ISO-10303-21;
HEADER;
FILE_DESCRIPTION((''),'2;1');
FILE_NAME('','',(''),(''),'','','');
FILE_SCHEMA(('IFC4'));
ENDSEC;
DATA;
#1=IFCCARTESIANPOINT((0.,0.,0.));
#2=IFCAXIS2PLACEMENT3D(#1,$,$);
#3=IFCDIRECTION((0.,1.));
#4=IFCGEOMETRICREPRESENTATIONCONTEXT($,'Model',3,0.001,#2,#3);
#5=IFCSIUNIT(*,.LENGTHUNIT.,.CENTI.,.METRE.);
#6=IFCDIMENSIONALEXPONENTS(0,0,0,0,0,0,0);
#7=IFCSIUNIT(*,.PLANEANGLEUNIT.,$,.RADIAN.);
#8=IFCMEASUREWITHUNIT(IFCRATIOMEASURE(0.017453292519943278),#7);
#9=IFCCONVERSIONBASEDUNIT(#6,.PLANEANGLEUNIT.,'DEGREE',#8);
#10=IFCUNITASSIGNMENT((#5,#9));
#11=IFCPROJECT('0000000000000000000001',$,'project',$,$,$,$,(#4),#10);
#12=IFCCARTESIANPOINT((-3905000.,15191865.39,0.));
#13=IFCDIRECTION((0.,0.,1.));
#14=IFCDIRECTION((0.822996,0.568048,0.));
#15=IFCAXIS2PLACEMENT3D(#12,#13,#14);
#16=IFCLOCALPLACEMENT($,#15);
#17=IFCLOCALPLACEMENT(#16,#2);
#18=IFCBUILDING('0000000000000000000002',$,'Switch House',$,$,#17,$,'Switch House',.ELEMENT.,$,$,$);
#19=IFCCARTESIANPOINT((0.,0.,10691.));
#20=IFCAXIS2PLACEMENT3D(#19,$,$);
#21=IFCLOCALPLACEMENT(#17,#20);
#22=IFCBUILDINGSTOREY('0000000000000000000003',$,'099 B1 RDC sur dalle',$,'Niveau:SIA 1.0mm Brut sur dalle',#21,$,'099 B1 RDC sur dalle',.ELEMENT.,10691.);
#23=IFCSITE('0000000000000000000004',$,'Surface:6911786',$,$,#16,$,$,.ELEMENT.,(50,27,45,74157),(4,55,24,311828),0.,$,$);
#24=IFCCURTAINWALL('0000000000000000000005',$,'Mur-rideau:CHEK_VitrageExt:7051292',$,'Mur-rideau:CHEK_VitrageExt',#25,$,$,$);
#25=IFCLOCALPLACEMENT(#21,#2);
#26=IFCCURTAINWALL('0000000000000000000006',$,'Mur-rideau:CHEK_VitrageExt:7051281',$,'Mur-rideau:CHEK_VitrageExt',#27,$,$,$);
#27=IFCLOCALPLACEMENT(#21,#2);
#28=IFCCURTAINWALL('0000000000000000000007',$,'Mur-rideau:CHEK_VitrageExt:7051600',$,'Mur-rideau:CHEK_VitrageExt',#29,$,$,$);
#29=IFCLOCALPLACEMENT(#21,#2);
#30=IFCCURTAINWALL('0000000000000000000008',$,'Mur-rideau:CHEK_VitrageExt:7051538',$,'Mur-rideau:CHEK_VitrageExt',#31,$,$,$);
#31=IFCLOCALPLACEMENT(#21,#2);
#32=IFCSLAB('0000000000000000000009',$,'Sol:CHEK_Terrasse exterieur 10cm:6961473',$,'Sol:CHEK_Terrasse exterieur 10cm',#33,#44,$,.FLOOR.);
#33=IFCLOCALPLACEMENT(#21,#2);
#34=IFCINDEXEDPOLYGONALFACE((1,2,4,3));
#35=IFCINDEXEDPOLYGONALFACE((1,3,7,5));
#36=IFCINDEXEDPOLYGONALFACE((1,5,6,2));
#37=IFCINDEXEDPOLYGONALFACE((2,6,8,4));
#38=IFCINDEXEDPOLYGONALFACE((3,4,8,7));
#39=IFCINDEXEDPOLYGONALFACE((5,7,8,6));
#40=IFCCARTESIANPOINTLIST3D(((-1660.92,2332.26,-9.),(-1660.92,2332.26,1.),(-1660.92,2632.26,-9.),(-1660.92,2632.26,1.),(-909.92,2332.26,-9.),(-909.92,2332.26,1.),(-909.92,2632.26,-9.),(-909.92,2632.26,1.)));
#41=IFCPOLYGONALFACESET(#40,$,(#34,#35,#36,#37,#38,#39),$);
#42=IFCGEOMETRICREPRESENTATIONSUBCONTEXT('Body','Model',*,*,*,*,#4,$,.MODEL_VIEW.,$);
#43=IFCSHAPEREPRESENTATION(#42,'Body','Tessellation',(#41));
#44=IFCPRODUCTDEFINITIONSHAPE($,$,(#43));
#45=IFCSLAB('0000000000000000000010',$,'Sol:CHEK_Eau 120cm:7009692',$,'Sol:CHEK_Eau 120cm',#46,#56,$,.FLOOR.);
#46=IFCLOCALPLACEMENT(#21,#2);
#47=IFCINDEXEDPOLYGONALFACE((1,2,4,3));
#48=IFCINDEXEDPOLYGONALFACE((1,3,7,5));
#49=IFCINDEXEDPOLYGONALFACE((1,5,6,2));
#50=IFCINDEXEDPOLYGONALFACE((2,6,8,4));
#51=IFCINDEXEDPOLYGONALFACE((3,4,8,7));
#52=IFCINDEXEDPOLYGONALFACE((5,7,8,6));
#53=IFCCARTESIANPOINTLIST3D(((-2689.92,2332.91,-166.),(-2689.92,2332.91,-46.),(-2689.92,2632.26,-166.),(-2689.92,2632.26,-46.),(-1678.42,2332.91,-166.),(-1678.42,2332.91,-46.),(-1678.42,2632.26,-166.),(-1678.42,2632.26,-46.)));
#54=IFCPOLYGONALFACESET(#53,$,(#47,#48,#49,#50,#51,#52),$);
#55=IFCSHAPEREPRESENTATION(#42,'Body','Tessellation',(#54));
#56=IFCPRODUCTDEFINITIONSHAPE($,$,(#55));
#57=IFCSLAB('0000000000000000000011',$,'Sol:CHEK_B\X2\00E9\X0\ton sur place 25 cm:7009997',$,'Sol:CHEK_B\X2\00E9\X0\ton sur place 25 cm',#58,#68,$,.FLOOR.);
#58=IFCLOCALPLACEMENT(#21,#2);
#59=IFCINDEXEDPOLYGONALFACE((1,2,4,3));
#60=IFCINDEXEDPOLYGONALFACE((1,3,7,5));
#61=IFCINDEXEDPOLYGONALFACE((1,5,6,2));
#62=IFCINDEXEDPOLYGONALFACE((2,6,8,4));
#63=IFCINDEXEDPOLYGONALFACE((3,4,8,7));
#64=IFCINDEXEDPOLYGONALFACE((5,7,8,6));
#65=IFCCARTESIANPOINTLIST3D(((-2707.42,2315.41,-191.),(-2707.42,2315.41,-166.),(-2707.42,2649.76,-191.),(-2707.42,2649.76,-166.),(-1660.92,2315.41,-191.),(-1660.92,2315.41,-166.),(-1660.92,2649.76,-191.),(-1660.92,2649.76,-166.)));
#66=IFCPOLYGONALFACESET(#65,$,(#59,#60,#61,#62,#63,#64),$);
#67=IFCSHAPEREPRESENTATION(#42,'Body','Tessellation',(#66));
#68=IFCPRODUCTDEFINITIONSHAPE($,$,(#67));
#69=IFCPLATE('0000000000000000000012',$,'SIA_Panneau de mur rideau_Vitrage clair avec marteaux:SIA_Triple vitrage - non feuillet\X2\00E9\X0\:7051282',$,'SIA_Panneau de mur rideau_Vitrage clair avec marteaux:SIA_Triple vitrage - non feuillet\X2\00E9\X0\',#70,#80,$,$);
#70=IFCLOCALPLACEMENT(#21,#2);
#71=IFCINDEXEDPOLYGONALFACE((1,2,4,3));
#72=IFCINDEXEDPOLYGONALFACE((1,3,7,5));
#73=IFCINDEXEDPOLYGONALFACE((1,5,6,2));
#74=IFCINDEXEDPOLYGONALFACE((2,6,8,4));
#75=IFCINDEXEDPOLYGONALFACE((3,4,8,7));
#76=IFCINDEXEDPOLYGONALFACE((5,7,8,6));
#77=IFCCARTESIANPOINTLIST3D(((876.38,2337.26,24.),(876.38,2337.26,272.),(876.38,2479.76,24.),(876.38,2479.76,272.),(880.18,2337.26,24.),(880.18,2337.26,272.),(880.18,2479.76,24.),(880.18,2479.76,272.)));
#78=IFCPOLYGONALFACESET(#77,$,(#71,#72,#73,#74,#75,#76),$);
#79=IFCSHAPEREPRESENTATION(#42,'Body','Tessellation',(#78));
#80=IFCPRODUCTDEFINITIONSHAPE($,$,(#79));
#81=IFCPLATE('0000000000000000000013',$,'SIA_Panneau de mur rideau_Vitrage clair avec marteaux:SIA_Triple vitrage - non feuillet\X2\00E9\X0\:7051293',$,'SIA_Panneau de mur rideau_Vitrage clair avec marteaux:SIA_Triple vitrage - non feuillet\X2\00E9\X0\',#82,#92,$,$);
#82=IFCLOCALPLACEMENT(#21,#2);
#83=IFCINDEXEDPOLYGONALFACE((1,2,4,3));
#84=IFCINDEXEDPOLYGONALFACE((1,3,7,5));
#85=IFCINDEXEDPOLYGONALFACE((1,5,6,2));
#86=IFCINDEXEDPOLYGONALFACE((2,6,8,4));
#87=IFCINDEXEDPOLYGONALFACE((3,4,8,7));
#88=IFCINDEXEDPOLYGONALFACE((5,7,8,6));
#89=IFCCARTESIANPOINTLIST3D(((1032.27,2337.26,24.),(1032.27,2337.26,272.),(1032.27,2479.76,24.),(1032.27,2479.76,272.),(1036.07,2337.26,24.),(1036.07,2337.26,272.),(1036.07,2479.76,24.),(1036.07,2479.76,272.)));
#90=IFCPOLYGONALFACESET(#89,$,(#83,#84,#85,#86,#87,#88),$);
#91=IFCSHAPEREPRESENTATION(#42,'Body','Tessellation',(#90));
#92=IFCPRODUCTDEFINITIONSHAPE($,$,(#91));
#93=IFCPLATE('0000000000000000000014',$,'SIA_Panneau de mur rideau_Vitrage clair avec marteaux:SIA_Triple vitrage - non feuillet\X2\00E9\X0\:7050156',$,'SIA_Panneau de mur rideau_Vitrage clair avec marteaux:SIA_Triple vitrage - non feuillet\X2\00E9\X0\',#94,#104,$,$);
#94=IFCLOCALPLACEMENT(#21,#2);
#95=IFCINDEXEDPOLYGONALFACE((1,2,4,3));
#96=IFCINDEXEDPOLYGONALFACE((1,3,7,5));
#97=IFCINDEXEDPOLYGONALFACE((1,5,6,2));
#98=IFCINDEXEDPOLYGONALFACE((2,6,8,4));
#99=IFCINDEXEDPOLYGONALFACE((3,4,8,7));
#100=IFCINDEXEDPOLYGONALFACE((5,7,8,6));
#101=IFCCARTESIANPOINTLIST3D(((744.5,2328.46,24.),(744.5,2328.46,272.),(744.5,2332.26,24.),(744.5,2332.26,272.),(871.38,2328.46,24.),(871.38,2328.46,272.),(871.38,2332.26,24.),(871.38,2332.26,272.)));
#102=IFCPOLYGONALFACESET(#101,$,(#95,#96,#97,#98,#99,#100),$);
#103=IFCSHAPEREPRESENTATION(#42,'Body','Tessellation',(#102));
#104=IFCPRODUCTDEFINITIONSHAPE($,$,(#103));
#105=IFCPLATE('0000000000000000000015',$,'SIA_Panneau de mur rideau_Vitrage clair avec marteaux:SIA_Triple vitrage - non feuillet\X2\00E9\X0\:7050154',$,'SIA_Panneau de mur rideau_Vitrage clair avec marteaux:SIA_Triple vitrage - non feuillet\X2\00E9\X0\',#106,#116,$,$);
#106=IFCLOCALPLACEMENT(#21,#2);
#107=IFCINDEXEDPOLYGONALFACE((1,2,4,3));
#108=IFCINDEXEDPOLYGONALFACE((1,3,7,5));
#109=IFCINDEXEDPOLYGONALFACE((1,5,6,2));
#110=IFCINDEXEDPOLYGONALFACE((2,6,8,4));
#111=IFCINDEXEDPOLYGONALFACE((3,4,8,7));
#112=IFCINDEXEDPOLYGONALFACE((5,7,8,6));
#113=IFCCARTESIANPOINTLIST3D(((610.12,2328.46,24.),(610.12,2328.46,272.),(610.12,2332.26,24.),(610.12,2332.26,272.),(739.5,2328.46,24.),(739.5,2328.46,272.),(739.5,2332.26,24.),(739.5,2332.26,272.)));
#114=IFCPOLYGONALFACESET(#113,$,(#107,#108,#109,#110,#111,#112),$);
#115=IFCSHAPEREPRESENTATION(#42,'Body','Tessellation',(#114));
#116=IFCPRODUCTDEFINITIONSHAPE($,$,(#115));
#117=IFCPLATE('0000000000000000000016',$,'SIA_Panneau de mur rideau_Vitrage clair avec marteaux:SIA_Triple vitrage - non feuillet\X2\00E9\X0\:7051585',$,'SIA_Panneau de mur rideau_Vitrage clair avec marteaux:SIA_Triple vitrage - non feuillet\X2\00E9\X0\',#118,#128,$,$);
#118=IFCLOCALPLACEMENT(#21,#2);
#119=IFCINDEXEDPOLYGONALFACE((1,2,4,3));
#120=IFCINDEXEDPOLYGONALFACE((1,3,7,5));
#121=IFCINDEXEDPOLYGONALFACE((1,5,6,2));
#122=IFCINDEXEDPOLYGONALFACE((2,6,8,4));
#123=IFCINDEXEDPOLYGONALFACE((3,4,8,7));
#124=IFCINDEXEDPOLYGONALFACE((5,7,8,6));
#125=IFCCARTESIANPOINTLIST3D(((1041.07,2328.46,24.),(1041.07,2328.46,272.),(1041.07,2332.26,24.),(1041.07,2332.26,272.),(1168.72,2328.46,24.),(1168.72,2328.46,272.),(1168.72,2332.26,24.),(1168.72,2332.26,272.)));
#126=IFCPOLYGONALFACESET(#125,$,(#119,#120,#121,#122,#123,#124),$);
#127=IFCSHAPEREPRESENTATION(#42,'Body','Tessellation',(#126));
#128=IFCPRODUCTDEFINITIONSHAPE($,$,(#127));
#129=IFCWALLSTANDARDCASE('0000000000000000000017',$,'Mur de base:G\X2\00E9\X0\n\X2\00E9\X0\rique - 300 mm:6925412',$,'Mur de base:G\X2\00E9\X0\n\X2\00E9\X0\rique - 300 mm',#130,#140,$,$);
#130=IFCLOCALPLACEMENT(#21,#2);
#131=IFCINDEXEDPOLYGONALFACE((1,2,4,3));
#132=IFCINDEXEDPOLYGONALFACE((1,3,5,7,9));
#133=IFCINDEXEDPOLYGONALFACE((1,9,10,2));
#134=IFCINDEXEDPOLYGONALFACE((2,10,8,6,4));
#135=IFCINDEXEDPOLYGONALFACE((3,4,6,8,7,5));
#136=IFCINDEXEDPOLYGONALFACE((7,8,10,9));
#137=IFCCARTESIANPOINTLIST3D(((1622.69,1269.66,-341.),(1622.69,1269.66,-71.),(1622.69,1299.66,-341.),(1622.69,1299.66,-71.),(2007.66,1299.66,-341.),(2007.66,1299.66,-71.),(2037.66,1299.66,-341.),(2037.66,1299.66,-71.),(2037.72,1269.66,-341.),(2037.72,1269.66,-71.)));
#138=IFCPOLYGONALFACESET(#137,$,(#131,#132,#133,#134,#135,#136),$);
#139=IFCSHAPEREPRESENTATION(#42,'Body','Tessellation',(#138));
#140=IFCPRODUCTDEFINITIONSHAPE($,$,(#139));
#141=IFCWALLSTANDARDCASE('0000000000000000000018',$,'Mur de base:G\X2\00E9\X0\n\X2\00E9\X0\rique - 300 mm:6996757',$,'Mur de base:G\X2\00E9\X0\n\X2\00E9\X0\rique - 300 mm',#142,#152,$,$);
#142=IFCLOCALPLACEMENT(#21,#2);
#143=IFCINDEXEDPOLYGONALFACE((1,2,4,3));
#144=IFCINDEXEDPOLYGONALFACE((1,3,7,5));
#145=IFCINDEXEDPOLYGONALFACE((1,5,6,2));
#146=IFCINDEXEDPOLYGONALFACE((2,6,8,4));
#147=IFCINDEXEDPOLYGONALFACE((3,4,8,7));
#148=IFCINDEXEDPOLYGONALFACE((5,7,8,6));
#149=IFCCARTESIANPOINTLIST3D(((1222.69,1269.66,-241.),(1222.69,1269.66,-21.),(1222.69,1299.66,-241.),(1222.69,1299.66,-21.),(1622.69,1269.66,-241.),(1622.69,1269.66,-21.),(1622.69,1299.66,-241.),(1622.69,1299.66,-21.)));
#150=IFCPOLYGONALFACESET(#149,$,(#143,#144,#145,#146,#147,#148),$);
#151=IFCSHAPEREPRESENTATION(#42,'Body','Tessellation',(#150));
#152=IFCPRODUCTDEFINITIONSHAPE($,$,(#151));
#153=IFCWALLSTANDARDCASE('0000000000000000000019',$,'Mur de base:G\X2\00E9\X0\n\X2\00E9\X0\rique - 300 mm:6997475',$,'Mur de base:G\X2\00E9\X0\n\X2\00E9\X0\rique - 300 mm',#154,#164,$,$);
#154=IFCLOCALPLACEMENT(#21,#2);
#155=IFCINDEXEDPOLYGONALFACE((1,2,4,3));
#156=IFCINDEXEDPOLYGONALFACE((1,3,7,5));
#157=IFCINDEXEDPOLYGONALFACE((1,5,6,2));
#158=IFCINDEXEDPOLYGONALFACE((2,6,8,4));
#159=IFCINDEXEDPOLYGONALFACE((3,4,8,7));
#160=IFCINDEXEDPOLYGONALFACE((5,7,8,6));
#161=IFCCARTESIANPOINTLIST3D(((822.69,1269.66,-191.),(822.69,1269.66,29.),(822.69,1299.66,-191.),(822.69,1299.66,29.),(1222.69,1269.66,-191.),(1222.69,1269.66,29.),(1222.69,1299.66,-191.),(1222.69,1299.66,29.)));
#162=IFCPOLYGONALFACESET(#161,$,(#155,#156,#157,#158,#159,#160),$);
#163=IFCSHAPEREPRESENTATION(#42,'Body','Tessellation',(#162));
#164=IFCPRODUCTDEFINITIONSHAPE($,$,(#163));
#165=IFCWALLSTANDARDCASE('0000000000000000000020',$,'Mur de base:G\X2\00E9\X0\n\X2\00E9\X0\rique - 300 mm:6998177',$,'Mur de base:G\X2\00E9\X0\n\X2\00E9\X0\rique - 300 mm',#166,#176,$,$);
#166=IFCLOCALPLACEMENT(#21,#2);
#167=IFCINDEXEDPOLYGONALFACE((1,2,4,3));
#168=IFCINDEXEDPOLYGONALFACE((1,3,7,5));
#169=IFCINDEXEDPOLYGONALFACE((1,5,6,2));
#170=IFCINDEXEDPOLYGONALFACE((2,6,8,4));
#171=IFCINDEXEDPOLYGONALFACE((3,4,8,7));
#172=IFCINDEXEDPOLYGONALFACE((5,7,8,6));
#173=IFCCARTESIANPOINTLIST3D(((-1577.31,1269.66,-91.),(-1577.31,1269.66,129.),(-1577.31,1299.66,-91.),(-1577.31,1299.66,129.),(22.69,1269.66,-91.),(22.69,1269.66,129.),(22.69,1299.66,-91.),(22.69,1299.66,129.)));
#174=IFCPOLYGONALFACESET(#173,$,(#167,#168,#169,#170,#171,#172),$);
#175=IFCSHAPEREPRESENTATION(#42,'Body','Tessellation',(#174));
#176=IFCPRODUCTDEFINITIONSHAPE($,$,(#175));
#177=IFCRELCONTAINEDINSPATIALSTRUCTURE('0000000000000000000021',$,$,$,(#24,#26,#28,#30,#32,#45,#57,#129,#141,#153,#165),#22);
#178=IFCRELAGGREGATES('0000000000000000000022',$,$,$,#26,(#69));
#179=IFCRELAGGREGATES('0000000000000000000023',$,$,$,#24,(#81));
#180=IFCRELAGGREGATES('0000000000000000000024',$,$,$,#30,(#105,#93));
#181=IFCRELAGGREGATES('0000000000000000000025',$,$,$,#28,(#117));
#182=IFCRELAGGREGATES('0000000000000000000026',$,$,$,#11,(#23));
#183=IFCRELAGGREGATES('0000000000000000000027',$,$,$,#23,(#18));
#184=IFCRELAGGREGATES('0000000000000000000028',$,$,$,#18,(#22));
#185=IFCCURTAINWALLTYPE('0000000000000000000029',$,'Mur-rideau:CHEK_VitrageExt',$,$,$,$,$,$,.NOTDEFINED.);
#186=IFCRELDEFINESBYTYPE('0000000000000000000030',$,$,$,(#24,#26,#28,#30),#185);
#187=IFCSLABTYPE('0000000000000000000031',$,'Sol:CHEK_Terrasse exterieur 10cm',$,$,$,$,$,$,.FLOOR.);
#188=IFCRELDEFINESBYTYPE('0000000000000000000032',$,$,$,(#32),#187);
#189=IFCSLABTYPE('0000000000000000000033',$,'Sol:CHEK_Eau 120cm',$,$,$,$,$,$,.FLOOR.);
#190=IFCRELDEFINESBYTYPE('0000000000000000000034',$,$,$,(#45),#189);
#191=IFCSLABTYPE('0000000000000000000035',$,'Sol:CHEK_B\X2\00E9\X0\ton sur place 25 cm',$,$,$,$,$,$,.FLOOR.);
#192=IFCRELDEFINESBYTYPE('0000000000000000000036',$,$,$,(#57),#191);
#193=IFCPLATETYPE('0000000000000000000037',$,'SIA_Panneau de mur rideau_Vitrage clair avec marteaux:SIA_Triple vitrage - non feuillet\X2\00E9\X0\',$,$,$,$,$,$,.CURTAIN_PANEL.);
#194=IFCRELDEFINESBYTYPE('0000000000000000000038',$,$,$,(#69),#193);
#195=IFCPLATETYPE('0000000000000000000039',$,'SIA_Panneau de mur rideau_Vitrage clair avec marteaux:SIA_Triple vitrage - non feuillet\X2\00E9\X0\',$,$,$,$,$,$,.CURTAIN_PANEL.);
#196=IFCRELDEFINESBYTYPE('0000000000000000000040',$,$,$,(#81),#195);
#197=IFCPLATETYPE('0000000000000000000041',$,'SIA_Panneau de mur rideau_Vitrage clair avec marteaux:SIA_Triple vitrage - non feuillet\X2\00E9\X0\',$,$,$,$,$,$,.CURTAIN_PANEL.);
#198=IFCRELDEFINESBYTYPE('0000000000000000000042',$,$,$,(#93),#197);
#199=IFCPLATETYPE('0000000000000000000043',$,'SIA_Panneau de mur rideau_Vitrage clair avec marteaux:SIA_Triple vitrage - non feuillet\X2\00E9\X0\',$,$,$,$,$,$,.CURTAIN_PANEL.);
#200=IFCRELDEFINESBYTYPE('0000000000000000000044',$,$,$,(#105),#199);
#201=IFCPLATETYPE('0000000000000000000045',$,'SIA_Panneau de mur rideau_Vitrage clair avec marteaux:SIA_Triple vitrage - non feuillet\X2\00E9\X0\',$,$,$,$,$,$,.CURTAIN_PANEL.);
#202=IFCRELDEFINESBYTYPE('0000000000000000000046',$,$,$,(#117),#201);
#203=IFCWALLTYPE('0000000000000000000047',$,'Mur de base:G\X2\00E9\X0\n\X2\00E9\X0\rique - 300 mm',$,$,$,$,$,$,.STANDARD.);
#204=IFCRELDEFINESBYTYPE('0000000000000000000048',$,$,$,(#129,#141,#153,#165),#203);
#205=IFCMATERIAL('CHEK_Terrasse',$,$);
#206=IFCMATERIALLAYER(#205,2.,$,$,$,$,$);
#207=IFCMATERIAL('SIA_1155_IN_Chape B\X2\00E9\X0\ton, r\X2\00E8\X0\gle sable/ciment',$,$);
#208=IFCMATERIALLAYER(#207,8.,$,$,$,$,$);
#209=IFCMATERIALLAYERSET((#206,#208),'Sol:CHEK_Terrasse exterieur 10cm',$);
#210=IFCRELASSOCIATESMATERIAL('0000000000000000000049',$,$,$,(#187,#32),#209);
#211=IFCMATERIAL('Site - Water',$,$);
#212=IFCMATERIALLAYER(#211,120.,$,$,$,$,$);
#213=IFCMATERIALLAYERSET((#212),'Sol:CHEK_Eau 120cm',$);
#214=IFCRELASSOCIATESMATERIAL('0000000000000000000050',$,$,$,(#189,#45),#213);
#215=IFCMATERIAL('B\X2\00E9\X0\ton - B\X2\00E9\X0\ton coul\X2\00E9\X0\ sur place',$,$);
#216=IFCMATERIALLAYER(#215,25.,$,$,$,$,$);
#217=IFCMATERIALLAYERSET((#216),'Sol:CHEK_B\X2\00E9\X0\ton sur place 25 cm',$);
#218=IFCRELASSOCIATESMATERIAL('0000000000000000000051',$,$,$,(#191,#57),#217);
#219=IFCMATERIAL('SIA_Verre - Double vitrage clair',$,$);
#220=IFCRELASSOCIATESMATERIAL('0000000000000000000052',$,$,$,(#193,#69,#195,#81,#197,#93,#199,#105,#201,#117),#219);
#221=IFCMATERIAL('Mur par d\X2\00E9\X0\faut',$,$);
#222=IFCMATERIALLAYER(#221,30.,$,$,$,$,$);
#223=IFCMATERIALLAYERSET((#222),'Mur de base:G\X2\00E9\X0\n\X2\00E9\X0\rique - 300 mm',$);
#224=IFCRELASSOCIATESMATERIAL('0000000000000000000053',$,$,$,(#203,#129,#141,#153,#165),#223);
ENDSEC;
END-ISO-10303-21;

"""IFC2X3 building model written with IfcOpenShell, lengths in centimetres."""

from ifc_helpers import new_model, entity, si_unit, converted_unit, direction, frame, frame_2d, origin, origin_2d_with_axis, place, context, subcontext, project, spatial, polyline, rectangle, outline, extrude, source, transform, mapped, material, layer, layer_set, layer_usage, type_object, type_shapes, element, aggregate, save


model = new_model("IFC2X3")

# Units and contexts
model_context = context("Model", 3, precision=0.001, world=origin(), true_north=direction((0.0, 1.0)))
body_context = subcontext(model_context, "Body", "Model", "MODEL_VIEW")
ifc_project = project(units=[si_unit("LENGTHUNIT", "METRE", prefix="CENTI"), converted_unit("PLANEANGLEUNIT", "DEGREE", entity("IfcRatioMeasure", 0.017453292519943278), si_unit("PLANEANGLEUNIT", "RADIAN"), dimensions=[0, 0, 0, 0, 0, 0, 0])], contexts=[model_context])

# Site, building, storey
site_placement = place(None, frame((-3905000.0, 15191865.39, 0.0), z_axis=(0.0, 0.0, 1.0), x_axis=(0.822996, 0.568048, 0.0)))
site = spatial("IfcSite", under=ifc_project, at=site_placement, Name="Surface:6911786", CompositionType="ELEMENT", RefLatitude=(50, 27, 45, 74157), RefLongitude=(4, 55, 24, 311828), RefElevation=0.0)
building_placement = place(site_placement, origin())
building = spatial("IfcBuilding", under=site, at=building_placement, Name="Switch House", LongName="Switch House", CompositionType="ELEMENT")
storey_placement = place(building_placement, frame((0.0, 0.0, 10691.0)))
storey = spatial("IfcBuildingStorey", under=building, at=storey_placement, Name="099 B1 RDC sur dalle", ObjectType="Niveau:SIA 1.0mm Brut sur dalle", LongName="099 B1 RDC sur dalle", CompositionType="ELEMENT", Elevation=10691.0)

# Curtain walls
curtain_wall_type = type_object("IfcCurtainWallType", Name="Mur-rideau:CHEK_VitrageExt", PredefinedType="NOTDEFINED")
curtain_wall_1_placement = place(storey_placement, frame((0.0, 0.0, -10691.0)))
curtain_wall_1 = element("IfcCurtainWall", 1, at=curtain_wall_1_placement, inside=storey, type_object=curtain_wall_type, Name="Mur-rideau:CHEK_VitrageExt:7051292", ObjectType="Mur-rideau:CHEK_VitrageExt")
curtain_wall_2_placement = place(storey_placement, frame((0.0, 0.0, -10691.0)))
curtain_wall_2 = element("IfcCurtainWall", 2, at=curtain_wall_2_placement, inside=storey, type_object=curtain_wall_type, Name="Mur-rideau:CHEK_VitrageExt:7051281", ObjectType="Mur-rideau:CHEK_VitrageExt")
curtain_wall_3_placement = place(storey_placement, frame((0.0, 0.0, -10691.0)))
curtain_wall_3 = element("IfcCurtainWall", 3, at=curtain_wall_3_placement, inside=storey, type_object=curtain_wall_type, Name="Mur-rideau:CHEK_VitrageExt:7051600", ObjectType="Mur-rideau:CHEK_VitrageExt")

# Curtain wall
curtain_wall_4_placement = place(storey_placement, frame((0.0, 0.0, -10691.0)))
curtain_wall_4 = element("IfcCurtainWall", 4, at=curtain_wall_4_placement, inside=storey, type_object=curtain_wall_type, Name="Mur-rideau:CHEK_VitrageExt:7051538", ObjectType="Mur-rideau:CHEK_VitrageExt")

# Slabs
ifc_material_1 = material(Name="CHEK_Terrasse")
ifc_layer_1 = layer(ifc_material_1, 2.0)
ifc_material_2 = material(Name="SIA_1155_IN_Chape Béton, règle sable/ciment")
ifc_layer_2 = layer(ifc_material_2, 8.0)
ifc_layer_set_1 = layer_set([ifc_layer_1, ifc_layer_2], Name="Sol:CHEK_Terrasse exterieur 10cm")
ifc_layer_usage_1 = layer_usage(ifc_layer_set_1, "AXIS3", "POSITIVE", 0.0)
slab_type_1 = type_object("IfcSlabType", Name="Sol:CHEK_Terrasse exterieur 10cm", PredefinedType="FLOOR", material=ifc_layer_set_1)
slab_1_placement = place(storey_placement, origin())
element("IfcSlab", 5, at=slab_1_placement, inside=storey, type_object=slab_type_1, material=ifc_layer_usage_1, Name="Sol:CHEK_Terrasse exterieur 10cm:6961473", ObjectType="Sol:CHEK_Terrasse exterieur 10cm", PredefinedType="FLOOR", context=body_context, shape_type="SweptSolid", body=[
    extrude(rectangle(XDim=300.0, YDim=751.0, at=frame_2d((0.0, 0.0), x_axis=(1.0, 0.0))), frame((-1285.42, 2482.26, 1.0), z_axis=(0.0, 0.0, -1.0), x_axis=(0.0, 1.0, 0.0)), (0.0, 0.0, 1.0), 10.0),
])
ifc_material_3 = material(Name="Site - Water")
ifc_layer_3 = layer(ifc_material_3, 120.0)
ifc_layer_set_2 = layer_set([ifc_layer_3], Name="Sol:CHEK_Eau 120cm")
ifc_layer_usage_2 = layer_usage(ifc_layer_set_2, "AXIS3", "POSITIVE", 0.0)
slab_type_2 = type_object("IfcSlabType", Name="Sol:CHEK_Eau 120cm", PredefinedType="FLOOR", material=ifc_layer_set_2)
slab_2_placement = place(storey_placement, origin())
element("IfcSlab", 6, at=slab_2_placement, inside=storey, type_object=slab_type_2, material=ifc_layer_usage_2, Name="Sol:CHEK_Eau 120cm:7009692", ObjectType="Sol:CHEK_Eau 120cm", PredefinedType="FLOOR", context=body_context, shape_type="SweptSolid", body=[
    extrude(rectangle(XDim=299.35, YDim=1011.5, at=frame_2d((0.0, 0.0), x_axis=(1.0, 0.0))), frame((-2184.17, 2482.59, -46.0), z_axis=(0.0, 0.0, -1.0), x_axis=(0.0, 1.0, 0.0)), (0.0, 0.0, 1.0), 120.0),
])
ifc_material_4 = material(Name="Béton - Béton coulé sur place")
ifc_layer_4 = layer(ifc_material_4, 25.0)
ifc_layer_set_3 = layer_set([ifc_layer_4], Name="Sol:CHEK_Béton sur place 25 cm")
ifc_layer_usage_3 = layer_usage(ifc_layer_set_3, "AXIS3", "POSITIVE", 0.0)
slab_type_3 = type_object("IfcSlabType", Name="Sol:CHEK_Béton sur place 25 cm", PredefinedType="FLOOR", material=ifc_layer_set_3)
slab_3_placement = place(storey_placement, origin())
element("IfcSlab", 7, at=slab_3_placement, inside=storey, type_object=slab_type_3, material=ifc_layer_usage_3, Name="Sol:CHEK_Béton sur place 25 cm:7009997", ObjectType="Sol:CHEK_Béton sur place 25 cm", PredefinedType="FLOOR", context=body_context, shape_type="SweptSolid", body=[
    extrude(rectangle(XDim=334.35, YDim=1046.5, at=frame_2d((0.0, 0.0), x_axis=(1.0, 0.0))), frame((-2184.17, 2482.59, -166.0), z_axis=(0.0, 0.0, -1.0), x_axis=(0.0, 1.0, 0.0)), (0.0, 0.0, 1.0), 25.0),
])

# Plates
ifc_material_5 = material(Name="SIA_Verre - Double vitrage clair")
plate_type_1 = type_object("IfcPlateType", Name="SIA_Panneau de mur rideau_Vitrage clair avec marteaux:SIA_Triple vitrage - non feuilleté", PredefinedType="CURTAIN_PANEL", material=ifc_material_5)
shared_shape_1 = source(origin(), body_context, "Body", "SweptSolid", [
    extrude(rectangle(XDim=3.8, YDim=142.5, at=origin_2d_with_axis()), frame((0.0, -1.9, 0.0), z_axis=(0.0, 0.0, 1.0), x_axis=(0.0, 1.0, 0.0)), (0.0, 0.0, 1.0), 248.0),
])
type_shapes(plate_type_1, [shared_shape_1])
plate_1_placement = place(curtain_wall_2_placement, frame((876.38, 2408.51, 10715.0), z_axis=(0.0, 0.0, 1.0), x_axis=(0.0, 1.0, 0.0)))
plate_1 = element("IfcPlate", 8, at=plate_1_placement, type_object=plate_type_1, material=ifc_material_5, Name="SIA_Panneau de mur rideau_Vitrage clair avec marteaux:SIA_Triple vitrage - non feuilleté:7051282", ObjectType="SIA_Panneau de mur rideau_Vitrage clair avec marteaux:SIA_Triple vitrage - non feuilleté", context=body_context, shape_type="MappedRepresentation", body=[
    mapped(shared_shape_1, transform((0.0, 0.0, 0.0), scale=1.0)),
])
aggregate(curtain_wall_2, [plate_1])
plate_type_2 = type_object("IfcPlateType", Name="SIA_Panneau de mur rideau_Vitrage clair avec marteaux:SIA_Triple vitrage - non feuilleté", PredefinedType="CURTAIN_PANEL", material=ifc_material_5)
shared_shape_2 = source(origin(), body_context, "Body", "SweptSolid", [
    extrude(rectangle(XDim=142.5, YDim=3.8, at=origin_2d_with_axis()), frame((0.0, 1.9, 0.0), z_axis=(0.0, 0.0, 1.0), x_axis=(-1.0, 0.0, 0.0)), (0.0, 0.0, 1.0), 248.0),
])
type_shapes(plate_type_2, [shared_shape_2])
plate_2_placement = place(curtain_wall_1_placement, frame((1036.07, 2408.51, 10715.0), z_axis=(0.0, 0.0, 1.0), x_axis=(0.0, 1.0, 0.0)))
plate_2 = element("IfcPlate", 9, at=plate_2_placement, type_object=plate_type_2, material=ifc_material_5, Name="SIA_Panneau de mur rideau_Vitrage clair avec marteaux:SIA_Triple vitrage - non feuilleté:7051293", ObjectType="SIA_Panneau de mur rideau_Vitrage clair avec marteaux:SIA_Triple vitrage - non feuilleté", context=body_context, shape_type="MappedRepresentation", body=[
    mapped(shared_shape_2, transform((0.0, 0.0, 0.0), scale=1.0)),
])
aggregate(curtain_wall_1, [plate_2])
plate_type_3 = type_object("IfcPlateType", Name="SIA_Panneau de mur rideau_Vitrage clair avec marteaux:SIA_Triple vitrage - non feuilleté", PredefinedType="CURTAIN_PANEL", material=ifc_material_5)
shared_shape_3 = source(origin(), body_context, "Body", "SweptSolid", [
    extrude(rectangle(XDim=3.8, YDim=126.88, at=origin_2d_with_axis()), frame((0.0, -1.9, 0.0), z_axis=(0.0, 0.0, 1.0), x_axis=(0.0, 1.0, 0.0)), (0.0, 0.0, 1.0), 248.0),
])
type_shapes(plate_type_3, [shared_shape_3])
plate_3_placement = place(curtain_wall_4_placement, frame((807.94, 2332.26, 10715.0)))
plate_3 = element("IfcPlate", 10, at=plate_3_placement, type_object=plate_type_3, material=ifc_material_5, Name="SIA_Panneau de mur rideau_Vitrage clair avec marteaux:SIA_Triple vitrage - non feuilleté:7050156", ObjectType="SIA_Panneau de mur rideau_Vitrage clair avec marteaux:SIA_Triple vitrage - non feuilleté", context=body_context, shape_type="MappedRepresentation", body=[
    mapped(shared_shape_3, transform((0.0, 0.0, 0.0), scale=1.0)),
])
plate_type_4 = type_object("IfcPlateType", Name="SIA_Panneau de mur rideau_Vitrage clair avec marteaux:SIA_Triple vitrage - non feuilleté", PredefinedType="CURTAIN_PANEL", material=ifc_material_5)
shared_shape_4 = source(origin(), body_context, "Body", "SweptSolid", [
    extrude(rectangle(XDim=3.8, YDim=129.38, at=origin_2d_with_axis()), frame((0.0, -1.9, 0.0), z_axis=(0.0, 0.0, 1.0), x_axis=(0.0, 1.0, 0.0)), (0.0, 0.0, 1.0), 248.0),
])
type_shapes(plate_type_4, [shared_shape_4])
plate_4_placement = place(curtain_wall_4_placement, frame((674.81, 2332.26, 10715.0)))
plate_4 = element("IfcPlate", 11, at=plate_4_placement, type_object=plate_type_4, material=ifc_material_5, Name="SIA_Panneau de mur rideau_Vitrage clair avec marteaux:SIA_Triple vitrage - non feuilleté:7050154", ObjectType="SIA_Panneau de mur rideau_Vitrage clair avec marteaux:SIA_Triple vitrage - non feuilleté", context=body_context, shape_type="MappedRepresentation", body=[
    mapped(shared_shape_4, transform((0.0, 0.0, 0.0), scale=1.0)),
])
aggregate(curtain_wall_4, [plate_4, plate_3])
plate_type_5 = type_object("IfcPlateType", Name="SIA_Panneau de mur rideau_Vitrage clair avec marteaux:SIA_Triple vitrage - non feuilleté", PredefinedType="CURTAIN_PANEL", material=ifc_material_5)
shared_shape_5 = source(origin(), body_context, "Body", "SweptSolid", [
    extrude(rectangle(XDim=3.8, YDim=127.65, at=origin_2d_with_axis()), frame((0.0, -1.9, 0.0), z_axis=(0.0, 0.0, 1.0), x_axis=(0.0, 1.0, 0.0)), (0.0, 0.0, 1.0), 248.0),
])
type_shapes(plate_type_5, [shared_shape_5])
plate_5_placement = place(curtain_wall_3_placement, frame((1104.9, 2332.26, 10715.0)))
plate_5 = element("IfcPlate", 12, at=plate_5_placement, type_object=plate_type_5, material=ifc_material_5, Name="SIA_Panneau de mur rideau_Vitrage clair avec marteaux:SIA_Triple vitrage - non feuilleté:7051585", ObjectType="SIA_Panneau de mur rideau_Vitrage clair avec marteaux:SIA_Triple vitrage - non feuilleté", context=body_context, shape_type="MappedRepresentation", body=[
    mapped(shared_shape_5, transform((0.0, 0.0, 0.0), scale=1.0)),
])
aggregate(curtain_wall_3, [plate_5])

# Walls
ifc_material_6 = material(Name="Mur par défaut")
ifc_layer_5 = layer(ifc_material_6, 30.0)
ifc_layer_set_4 = layer_set([ifc_layer_5], Name="Mur de base:Générique - 300 mm")
ifc_layer_usage_4 = layer_usage(ifc_layer_set_4, "AXIS2", "POSITIVE", -15.0)
wall_type_1 = type_object("IfcWallType", Name="Mur de base:Générique - 300 mm", PredefinedType="STANDARD", material=ifc_layer_set_4)
wall_1_placement = place(storey_placement, frame((2037.72, 1284.66, -341.0), z_axis=(0.0, 0.0, 1.0), x_axis=(-1.0, 0.0, 0.0)))
element("IfcWallStandardCase", 13, at=wall_1_placement, inside=storey, type_object=wall_type_1, material=ifc_layer_usage_4, Name="Mur de base:Générique - 300 mm:6925412", ObjectType="Mur de base:Générique - 300 mm", context=body_context, shape_type="SweptSolid", body=[
    extrude(outline(polyline([(415.03, -15.0), (415.03, 15.0), (0.0, 15.0), (0.07, -15.0), (30.07, -15.0), (415.03, -15.0)])), origin(), (0.0, 0.0, 1.0), 270.0),
])
ifc_layer_usage_5 = layer_usage(ifc_layer_set_4, "AXIS2", "NEGATIVE", 15.0)
wall_2_placement = place(storey_placement, frame((1622.69, 1284.66, -241.0), z_axis=(0.0, 0.0, 1.0), x_axis=(-1.0, 0.0, 0.0)))
element("IfcWallStandardCase", 14, at=wall_2_placement, inside=storey, type_object=wall_type_1, material=ifc_layer_usage_5, Name="Mur de base:Générique - 300 mm:6996757", ObjectType="Mur de base:Générique - 300 mm", context=body_context, shape_type="SweptSolid", body=[
    extrude(rectangle(XDim=400.0, YDim=30.0, at=frame_2d((200.0, 0.0), x_axis=(-1.0, 0.0))), origin(), (0.0, 0.0, 1.0), 220.0),
])
wall_3_placement = place(storey_placement, frame((1222.69, 1284.66, -191.0), z_axis=(0.0, 0.0, 1.0), x_axis=(-1.0, 0.0, 0.0)))
element("IfcWallStandardCase", 15, at=wall_3_placement, inside=storey, type_object=wall_type_1, material=ifc_layer_usage_5, Name="Mur de base:Générique - 300 mm:6997475", ObjectType="Mur de base:Générique - 300 mm", context=body_context, shape_type="SweptSolid", body=[
    extrude(rectangle(XDim=400.0, YDim=30.0, at=frame_2d((200.0, 0.0), x_axis=(-1.0, 0.0))), origin(), (0.0, 0.0, 1.0), 220.0),
])
wall_4_placement = place(storey_placement, frame((22.69, 1284.66, -91.0), z_axis=(0.0, 0.0, 1.0), x_axis=(-1.0, 0.0, 0.0)))
element("IfcWallStandardCase", 16, at=wall_4_placement, inside=storey, type_object=wall_type_1, material=ifc_layer_usage_5, Name="Mur de base:Générique - 300 mm:6998177", ObjectType="Mur de base:Générique - 300 mm", context=body_context, shape_type="SweptSolid", body=[
    extrude(rectangle(XDim=1600.0, YDim=30.0, at=frame_2d((800.0, 0.0), x_axis=(-1.0, 0.0))), origin(), (0.0, 0.0, 1.0), 220.0),
])

save(model, "model.ifc")
